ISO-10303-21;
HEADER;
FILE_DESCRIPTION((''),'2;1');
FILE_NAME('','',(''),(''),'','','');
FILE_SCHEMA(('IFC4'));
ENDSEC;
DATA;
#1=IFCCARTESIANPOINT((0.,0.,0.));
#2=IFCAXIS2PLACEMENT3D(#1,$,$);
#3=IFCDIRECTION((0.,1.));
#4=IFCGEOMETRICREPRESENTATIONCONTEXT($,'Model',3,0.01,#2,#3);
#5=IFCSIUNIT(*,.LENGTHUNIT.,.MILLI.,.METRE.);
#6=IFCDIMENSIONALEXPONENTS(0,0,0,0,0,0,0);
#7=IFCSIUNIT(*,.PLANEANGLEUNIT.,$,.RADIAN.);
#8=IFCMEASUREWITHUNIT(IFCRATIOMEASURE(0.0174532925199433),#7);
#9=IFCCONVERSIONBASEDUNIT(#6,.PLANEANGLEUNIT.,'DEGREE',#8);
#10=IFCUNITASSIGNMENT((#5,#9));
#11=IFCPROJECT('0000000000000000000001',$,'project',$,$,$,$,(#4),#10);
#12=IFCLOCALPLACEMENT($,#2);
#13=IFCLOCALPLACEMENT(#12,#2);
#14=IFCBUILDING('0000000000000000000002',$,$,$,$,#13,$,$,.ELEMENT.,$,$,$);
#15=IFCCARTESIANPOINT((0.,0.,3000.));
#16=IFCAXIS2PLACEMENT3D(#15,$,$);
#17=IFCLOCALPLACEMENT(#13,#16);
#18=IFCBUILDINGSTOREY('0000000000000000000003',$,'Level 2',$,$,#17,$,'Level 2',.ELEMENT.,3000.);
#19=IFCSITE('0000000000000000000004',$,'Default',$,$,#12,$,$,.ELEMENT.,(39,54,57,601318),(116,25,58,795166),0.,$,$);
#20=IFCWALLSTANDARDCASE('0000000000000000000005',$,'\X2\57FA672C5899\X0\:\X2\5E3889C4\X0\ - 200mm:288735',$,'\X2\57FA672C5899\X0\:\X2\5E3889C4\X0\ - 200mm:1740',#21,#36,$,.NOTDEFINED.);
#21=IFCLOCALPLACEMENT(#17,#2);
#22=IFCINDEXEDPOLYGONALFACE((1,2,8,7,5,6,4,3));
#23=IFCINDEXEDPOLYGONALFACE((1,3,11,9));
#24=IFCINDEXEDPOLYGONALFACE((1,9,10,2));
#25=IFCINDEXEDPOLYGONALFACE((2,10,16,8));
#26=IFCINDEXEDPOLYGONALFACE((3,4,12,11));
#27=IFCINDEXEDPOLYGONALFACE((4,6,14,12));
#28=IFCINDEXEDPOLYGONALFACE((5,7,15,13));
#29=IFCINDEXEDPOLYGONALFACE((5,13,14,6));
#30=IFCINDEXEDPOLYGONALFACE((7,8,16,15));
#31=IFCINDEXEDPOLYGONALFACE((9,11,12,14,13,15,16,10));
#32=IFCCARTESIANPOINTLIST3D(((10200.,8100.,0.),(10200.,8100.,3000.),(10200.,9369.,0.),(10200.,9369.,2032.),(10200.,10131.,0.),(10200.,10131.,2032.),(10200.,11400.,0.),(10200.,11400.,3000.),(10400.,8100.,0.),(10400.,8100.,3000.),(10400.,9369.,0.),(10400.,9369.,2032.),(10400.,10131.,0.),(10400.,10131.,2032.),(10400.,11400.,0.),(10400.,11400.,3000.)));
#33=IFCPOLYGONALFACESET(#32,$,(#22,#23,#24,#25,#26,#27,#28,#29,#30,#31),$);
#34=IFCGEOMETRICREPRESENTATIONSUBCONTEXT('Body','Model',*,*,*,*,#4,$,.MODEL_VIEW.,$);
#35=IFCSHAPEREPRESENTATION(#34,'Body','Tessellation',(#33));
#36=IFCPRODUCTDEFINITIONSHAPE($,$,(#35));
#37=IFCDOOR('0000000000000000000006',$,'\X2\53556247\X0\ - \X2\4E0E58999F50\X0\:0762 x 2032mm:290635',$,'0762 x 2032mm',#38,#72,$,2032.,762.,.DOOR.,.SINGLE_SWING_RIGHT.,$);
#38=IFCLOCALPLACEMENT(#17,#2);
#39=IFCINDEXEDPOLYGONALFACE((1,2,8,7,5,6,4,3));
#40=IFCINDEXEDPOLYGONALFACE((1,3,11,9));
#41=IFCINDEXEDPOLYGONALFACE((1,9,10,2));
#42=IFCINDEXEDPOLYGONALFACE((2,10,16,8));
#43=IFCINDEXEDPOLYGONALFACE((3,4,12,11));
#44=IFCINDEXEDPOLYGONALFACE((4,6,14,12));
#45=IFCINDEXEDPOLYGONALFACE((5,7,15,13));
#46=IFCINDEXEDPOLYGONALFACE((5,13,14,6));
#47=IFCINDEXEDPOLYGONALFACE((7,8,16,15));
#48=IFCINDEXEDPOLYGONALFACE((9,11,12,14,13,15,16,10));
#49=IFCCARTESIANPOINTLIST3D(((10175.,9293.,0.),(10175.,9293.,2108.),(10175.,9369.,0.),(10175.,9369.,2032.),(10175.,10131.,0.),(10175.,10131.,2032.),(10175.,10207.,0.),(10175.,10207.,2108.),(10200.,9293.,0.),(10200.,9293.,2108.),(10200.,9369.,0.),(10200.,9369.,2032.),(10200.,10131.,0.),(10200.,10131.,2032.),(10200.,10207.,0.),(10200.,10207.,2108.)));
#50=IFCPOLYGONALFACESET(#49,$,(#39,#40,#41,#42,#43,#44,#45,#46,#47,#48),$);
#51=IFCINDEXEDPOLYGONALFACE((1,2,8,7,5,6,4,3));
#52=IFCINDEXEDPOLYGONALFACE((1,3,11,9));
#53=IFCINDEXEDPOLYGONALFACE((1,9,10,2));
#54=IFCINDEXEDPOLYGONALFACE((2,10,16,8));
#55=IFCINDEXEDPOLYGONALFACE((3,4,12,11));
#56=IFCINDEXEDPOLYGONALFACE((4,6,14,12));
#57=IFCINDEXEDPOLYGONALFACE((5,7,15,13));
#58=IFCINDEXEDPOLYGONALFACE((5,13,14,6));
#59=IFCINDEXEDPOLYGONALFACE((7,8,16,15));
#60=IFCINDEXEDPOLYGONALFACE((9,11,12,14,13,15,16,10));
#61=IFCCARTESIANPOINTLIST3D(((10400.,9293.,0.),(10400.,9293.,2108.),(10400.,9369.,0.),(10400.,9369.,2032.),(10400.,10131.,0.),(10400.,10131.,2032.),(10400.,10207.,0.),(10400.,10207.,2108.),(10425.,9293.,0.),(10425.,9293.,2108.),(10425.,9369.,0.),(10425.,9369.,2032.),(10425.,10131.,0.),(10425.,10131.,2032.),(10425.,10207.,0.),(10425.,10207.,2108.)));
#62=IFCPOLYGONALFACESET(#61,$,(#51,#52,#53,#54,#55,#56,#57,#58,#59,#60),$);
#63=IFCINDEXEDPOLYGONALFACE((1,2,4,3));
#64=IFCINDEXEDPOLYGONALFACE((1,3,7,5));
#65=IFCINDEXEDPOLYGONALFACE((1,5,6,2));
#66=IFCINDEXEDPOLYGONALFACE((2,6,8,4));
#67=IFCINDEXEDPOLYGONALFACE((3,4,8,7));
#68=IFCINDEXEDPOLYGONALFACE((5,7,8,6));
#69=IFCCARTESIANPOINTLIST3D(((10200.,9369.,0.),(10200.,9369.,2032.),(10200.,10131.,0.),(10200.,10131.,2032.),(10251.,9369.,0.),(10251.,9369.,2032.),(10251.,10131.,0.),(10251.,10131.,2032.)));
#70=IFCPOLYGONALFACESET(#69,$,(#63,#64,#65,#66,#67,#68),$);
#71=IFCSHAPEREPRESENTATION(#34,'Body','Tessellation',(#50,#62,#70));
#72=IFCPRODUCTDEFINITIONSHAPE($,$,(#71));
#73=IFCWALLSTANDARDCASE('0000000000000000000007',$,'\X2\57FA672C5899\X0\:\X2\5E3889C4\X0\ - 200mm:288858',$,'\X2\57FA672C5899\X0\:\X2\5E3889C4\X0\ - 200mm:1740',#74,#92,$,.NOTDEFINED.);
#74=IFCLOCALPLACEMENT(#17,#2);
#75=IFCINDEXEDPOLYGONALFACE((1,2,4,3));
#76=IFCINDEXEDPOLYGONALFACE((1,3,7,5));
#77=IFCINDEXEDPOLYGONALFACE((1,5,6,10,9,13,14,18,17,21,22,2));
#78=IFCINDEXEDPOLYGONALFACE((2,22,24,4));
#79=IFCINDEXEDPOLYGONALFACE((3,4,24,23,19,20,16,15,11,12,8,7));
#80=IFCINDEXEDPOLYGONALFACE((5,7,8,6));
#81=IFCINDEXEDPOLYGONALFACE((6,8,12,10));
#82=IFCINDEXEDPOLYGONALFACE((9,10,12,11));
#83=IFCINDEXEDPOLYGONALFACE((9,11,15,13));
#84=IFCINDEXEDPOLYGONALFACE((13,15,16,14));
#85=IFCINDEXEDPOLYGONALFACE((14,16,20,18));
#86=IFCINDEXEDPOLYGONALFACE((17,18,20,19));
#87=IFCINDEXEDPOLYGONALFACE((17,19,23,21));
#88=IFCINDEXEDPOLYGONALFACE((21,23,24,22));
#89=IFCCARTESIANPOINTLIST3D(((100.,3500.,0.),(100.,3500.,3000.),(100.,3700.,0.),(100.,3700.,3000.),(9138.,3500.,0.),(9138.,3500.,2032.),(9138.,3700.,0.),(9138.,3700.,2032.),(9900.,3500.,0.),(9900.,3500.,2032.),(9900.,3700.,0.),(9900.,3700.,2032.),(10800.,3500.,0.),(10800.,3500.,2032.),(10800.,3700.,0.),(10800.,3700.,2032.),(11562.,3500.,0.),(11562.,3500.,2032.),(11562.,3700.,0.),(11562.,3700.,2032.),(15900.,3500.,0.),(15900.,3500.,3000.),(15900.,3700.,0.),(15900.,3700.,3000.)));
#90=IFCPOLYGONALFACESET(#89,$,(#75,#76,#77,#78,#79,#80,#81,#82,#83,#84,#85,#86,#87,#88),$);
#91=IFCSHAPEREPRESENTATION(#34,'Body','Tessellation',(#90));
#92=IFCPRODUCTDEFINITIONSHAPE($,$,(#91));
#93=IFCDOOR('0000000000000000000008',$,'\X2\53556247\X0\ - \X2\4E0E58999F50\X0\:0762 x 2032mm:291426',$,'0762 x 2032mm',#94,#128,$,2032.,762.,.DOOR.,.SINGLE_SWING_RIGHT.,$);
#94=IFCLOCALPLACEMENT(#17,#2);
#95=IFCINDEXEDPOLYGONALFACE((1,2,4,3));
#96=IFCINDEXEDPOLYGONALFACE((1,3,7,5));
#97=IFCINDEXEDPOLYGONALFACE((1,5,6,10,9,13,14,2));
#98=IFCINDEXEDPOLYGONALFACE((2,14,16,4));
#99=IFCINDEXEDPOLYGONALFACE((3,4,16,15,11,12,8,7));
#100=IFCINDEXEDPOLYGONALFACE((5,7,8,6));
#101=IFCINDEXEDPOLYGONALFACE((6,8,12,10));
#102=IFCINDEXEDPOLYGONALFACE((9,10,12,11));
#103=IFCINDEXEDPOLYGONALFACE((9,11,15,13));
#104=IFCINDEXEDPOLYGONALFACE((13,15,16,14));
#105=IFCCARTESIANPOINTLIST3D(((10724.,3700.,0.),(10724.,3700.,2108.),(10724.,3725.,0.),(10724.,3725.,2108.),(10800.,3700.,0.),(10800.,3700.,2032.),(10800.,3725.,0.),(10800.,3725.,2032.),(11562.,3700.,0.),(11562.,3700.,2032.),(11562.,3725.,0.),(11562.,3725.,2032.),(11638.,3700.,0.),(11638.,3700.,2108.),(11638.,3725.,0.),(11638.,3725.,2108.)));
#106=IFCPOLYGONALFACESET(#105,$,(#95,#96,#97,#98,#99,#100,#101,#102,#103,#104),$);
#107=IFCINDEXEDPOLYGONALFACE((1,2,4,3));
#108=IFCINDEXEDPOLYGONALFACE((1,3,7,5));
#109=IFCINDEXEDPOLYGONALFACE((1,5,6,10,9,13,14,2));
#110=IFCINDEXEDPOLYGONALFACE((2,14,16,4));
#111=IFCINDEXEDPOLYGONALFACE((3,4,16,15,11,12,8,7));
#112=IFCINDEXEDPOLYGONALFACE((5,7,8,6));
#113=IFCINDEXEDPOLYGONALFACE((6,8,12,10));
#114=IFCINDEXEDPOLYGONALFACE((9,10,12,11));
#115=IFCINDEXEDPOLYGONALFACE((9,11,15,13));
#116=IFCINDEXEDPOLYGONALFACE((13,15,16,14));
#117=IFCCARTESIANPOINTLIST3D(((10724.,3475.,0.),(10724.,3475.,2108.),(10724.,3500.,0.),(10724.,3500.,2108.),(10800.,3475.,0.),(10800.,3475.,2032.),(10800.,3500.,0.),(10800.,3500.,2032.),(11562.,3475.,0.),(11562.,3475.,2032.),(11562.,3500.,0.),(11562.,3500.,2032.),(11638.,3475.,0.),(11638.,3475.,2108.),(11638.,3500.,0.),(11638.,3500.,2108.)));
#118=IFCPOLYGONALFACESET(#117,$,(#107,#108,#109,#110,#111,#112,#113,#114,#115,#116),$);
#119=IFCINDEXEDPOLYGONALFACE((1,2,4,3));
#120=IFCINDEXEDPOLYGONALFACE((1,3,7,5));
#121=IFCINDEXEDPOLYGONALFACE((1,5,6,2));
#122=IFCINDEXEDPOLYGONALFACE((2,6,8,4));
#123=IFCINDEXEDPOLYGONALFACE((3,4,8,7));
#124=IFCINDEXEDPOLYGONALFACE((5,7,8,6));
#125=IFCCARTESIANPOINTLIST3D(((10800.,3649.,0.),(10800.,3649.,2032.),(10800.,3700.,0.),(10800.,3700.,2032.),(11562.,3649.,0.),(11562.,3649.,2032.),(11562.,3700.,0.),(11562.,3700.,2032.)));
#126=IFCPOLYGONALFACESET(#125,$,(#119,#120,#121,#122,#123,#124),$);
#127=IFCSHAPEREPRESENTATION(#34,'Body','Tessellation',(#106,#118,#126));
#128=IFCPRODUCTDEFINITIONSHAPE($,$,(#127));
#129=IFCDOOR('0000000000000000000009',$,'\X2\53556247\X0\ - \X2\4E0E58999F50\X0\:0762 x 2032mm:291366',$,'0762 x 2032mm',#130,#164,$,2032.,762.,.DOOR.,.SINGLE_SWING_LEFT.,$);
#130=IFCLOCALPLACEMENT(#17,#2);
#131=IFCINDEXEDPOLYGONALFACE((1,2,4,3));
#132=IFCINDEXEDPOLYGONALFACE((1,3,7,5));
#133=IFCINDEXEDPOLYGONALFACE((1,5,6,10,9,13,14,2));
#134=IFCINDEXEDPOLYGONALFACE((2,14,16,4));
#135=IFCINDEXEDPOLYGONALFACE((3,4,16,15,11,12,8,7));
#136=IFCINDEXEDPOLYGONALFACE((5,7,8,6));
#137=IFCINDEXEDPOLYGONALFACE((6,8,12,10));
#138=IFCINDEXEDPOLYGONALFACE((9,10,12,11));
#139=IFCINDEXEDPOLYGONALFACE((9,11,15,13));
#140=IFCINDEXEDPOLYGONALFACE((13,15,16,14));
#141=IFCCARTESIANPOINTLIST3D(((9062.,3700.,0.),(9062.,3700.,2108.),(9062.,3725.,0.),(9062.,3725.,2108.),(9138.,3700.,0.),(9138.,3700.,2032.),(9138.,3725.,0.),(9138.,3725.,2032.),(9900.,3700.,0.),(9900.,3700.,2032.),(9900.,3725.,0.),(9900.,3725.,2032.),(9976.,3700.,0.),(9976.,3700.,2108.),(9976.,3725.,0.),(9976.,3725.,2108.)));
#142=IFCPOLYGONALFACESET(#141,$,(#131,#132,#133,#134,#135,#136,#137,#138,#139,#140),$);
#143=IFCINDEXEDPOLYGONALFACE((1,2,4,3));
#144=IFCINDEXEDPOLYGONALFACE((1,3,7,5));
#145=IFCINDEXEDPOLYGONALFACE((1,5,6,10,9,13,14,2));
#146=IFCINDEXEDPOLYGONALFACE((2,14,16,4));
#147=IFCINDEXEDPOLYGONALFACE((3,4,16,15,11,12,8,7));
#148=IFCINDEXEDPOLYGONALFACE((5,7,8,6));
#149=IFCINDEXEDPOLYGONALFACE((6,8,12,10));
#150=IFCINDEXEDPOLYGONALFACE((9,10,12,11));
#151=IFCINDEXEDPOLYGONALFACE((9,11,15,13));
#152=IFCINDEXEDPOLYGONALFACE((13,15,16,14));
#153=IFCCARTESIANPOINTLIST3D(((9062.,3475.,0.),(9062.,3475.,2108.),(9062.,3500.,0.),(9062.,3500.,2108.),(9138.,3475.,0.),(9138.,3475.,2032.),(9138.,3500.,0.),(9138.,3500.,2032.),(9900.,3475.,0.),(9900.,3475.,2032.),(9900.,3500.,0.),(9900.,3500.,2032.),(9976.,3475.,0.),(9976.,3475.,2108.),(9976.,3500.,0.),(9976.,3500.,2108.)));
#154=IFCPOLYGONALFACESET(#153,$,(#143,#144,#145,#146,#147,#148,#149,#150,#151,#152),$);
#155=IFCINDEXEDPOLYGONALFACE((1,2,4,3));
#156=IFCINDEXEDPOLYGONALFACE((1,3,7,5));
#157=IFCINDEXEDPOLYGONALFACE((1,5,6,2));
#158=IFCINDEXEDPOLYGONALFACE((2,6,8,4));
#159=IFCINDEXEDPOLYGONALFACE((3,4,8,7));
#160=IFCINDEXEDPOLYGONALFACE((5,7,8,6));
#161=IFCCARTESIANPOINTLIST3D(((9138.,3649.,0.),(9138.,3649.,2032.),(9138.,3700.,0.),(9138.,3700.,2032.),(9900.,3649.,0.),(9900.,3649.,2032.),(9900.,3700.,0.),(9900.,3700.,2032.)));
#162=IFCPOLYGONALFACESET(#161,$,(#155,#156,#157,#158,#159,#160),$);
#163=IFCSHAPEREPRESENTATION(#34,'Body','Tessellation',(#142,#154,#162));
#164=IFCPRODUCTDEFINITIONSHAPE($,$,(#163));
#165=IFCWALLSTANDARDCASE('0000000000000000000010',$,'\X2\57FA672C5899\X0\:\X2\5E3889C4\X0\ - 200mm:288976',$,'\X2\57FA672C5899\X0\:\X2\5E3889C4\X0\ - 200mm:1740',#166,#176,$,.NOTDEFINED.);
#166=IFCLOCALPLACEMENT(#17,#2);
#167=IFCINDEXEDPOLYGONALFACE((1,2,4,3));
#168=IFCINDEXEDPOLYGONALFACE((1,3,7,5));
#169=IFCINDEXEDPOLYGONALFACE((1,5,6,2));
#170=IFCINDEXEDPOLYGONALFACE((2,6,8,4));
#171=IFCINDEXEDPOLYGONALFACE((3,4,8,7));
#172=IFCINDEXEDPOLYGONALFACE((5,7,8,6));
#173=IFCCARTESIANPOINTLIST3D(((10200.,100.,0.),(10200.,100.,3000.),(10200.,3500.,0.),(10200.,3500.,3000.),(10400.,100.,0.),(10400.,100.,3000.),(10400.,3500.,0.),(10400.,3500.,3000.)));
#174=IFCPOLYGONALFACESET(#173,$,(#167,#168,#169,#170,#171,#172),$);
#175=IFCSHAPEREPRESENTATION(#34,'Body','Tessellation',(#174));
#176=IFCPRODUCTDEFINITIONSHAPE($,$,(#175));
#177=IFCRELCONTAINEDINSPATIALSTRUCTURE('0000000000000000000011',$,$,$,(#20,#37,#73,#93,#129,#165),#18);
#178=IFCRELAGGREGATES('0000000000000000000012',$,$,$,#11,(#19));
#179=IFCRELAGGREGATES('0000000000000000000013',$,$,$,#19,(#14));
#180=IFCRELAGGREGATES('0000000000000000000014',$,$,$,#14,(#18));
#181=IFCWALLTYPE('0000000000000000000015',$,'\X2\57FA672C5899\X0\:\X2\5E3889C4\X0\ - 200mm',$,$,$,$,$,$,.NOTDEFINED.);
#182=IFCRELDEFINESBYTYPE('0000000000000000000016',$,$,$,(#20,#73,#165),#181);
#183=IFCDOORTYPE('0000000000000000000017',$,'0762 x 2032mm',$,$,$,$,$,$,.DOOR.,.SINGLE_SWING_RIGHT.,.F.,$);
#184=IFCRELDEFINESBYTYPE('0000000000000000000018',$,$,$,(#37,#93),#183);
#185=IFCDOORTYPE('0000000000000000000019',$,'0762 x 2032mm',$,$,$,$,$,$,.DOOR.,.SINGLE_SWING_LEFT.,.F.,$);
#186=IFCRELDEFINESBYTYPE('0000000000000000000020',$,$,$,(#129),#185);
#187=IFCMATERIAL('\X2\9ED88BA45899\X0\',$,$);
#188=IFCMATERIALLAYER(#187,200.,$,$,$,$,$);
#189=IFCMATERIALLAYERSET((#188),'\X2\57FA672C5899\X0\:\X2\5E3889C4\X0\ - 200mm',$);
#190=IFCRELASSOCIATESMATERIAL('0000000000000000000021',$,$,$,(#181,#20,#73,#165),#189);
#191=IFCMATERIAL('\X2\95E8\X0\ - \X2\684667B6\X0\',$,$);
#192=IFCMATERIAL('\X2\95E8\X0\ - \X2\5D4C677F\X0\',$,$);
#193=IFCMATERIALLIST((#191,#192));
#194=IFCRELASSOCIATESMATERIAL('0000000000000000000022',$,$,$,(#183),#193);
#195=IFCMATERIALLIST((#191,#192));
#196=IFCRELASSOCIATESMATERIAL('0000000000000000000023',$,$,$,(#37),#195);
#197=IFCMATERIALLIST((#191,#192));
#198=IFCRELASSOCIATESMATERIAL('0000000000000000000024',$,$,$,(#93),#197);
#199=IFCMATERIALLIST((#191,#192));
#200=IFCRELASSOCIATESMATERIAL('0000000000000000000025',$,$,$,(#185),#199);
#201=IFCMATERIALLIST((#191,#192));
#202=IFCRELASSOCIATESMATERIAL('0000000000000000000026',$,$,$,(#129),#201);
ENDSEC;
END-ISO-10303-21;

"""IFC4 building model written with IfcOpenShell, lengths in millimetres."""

from ifc_helpers import new_model, entity, si_unit, converted_unit, direction, frame, frame_2d, origin, origin_2d_with_axis, place, context, subcontext, project, spatial, polyline, rectangle, outline, extrude, source, transform, mapped, material, material_list, layer, layer_set, layer_usage, type_object, type_shapes, element, fill, save


model = new_model("IFC4")

# Units and contexts
model_context = context("Model", 3, precision=0.01, world=origin(), true_north=direction((0.0, 1.0)))
body_context = subcontext(model_context, "Body", "Model", "MODEL_VIEW")
ifc_project = project(units=[si_unit("LENGTHUNIT", "METRE", prefix="MILLI"), converted_unit("PLANEANGLEUNIT", "DEGREE", entity("IfcRatioMeasure", 0.0174532925199433), si_unit("PLANEANGLEUNIT", "RADIAN"), dimensions=[0, 0, 0, 0, 0, 0, 0])], contexts=[model_context])

# Site, building, storey
site_placement = place(None, origin())
site = spatial("IfcSite", under=ifc_project, at=site_placement, Name="Default", CompositionType="ELEMENT", RefLatitude=(39, 54, 57, 601318), RefLongitude=(116, 25, 58, 795166), RefElevation=0.0)
building_placement = place(site_placement, origin())
building = spatial("IfcBuilding", under=site, at=building_placement, CompositionType="ELEMENT")
storey_placement = place(building_placement, frame((0.0, 0.0, 3000.0)))
storey = spatial("IfcBuildingStorey", under=building, at=storey_placement, Name="Level 2", LongName="Level 2", CompositionType="ELEMENT", Elevation=3000.0)

# Shared definitions
ifc_material_1 = material(Name="默认墙")
ifc_layer = layer(ifc_material_1, 200.0)
ifc_layer_set = layer_set([ifc_layer], Name="基本墙:常规 - 200mm")
wall_type = type_object("IfcWallType", Name="基本墙:常规 - 200mm", PredefinedType="NOTDEFINED", material=ifc_layer_set)

# Wall, opening, door
ifc_layer_usage_1 = layer_usage(ifc_layer_set, "AXIS2", "NEGATIVE", 100.0)
wall_1_placement = place(storey_placement, frame((10300.0, 11400.0, 0.0), z_axis=(0.0, 0.0, 1.0), x_axis=(0.0, -1.0, 0.0)))
wall_1 = element("IfcWallStandardCase", 1, at=wall_1_placement, inside=storey, type_object=wall_type, material=ifc_layer_usage_1, Name="基本墙:常规 - 200mm:288735", ObjectType="基本墙:常规 - 200mm:1740", PredefinedType="NOTDEFINED", context=body_context, shape_type="SweptSolid", body=[
    extrude(rectangle(XDim=3300.0, YDim=200.0, at=frame_2d((1650.0, 0.0), x_axis=(-1.0, 0.0))), origin(), (0.0, 0.0, 1.0), 3000.0),
])
opening_1_placement = place(wall_1_placement, frame((2031.0, 100.0, 0.0)))
opening_1 = element("IfcOpeningElement", 2, at=opening_1_placement, cuts=wall_1, ObjectType="Opening", PredefinedType="OPENING", context=body_context, shape_type="SweptSolid", body=[
    extrude(rectangle(XDim=762.0, YDim=2032.0, at=frame_2d((1016.0, 381.0), x_axis=(0.0, 1.0))), frame((0.0, 0.0, 0.0), z_axis=(0.0, -1.0, 0.0), x_axis=(0.0, 0.0, 1.0)), (0.0, 0.0, 1.0), 200.0),
])
ifc_material_2 = material(Name="门 - 框架")
ifc_material_3 = material(Name="门 - 嵌板")
ifc_material_list_1 = material_list([ifc_material_2, ifc_material_3])
ifc_material_list_2 = material_list([ifc_material_2, ifc_material_3])
door_type_1 = type_object("IfcDoorType", Name="0762 x 2032mm", OperationType="SINGLE_SWING_RIGHT", ParameterTakesPrecedence=False, PredefinedType="DOOR", material=ifc_material_list_2)
shared_shape_1 = source(origin(), body_context, "Body", "SweptSolid", [
    extrude(outline(polyline([(-457.0, -1073.0), (457.0, -1073.0), (457.0, 1035.0), (381.0, 1035.0), (381.0, -997.0), (-381.0, -997.0), (-381.0, 1035.0), (-457.0, 1035.0), (-457.0, -1073.0)])), frame((381.0, 200.0, 1035.0), z_axis=(0.0, 1.0, 0.0), x_axis=(1.0, 0.0, 0.0)), (0.0, 0.0, 1.0), 25.0),
    extrude(outline(polyline([(-1073.0, -457.0), (1035.0, -457.0), (1035.0, -381.0), (-997.0, -381.0), (-997.0, 381.0), (1035.0, 381.0), (1035.0, 457.0), (-1073.0, 457.0), (-1073.0, -457.0)])), frame((381.0, -25.0, 1035.0), z_axis=(0.0, 1.0, 0.0), x_axis=(0.0, 0.0, -1.0)), (0.0, 0.0, 1.0), 25.0),
    extrude(rectangle(XDim=51.0, YDim=762.0, at=origin_2d_with_axis()), frame((381.0, 174.5, 0.0), z_axis=(0.0, 0.0, 1.0), x_axis=(0.0, 1.0, 0.0)), (0.0, 0.0, 1.0), 2032.0),
])
type_shapes(door_type_1, [shared_shape_1])
door_1_placement = place(opening_1_placement, frame((0.0, 0.0, 0.0), z_axis=(0.0, 0.0, 1.0), x_axis=(-1.0, 0.0, 0.0)))
door_1 = element("IfcDoor", 3, at=door_1_placement, inside=storey, type_object=door_type_1, material=ifc_material_list_1, Name="单扇 - 与墙齐:0762 x 2032mm:290635", ObjectType="0762 x 2032mm", OperationType="SINGLE_SWING_RIGHT", OverallHeight=2032.0, OverallWidth=762.0, PredefinedType="DOOR", context=body_context, shape_type="MappedRepresentation", body=[
    mapped(shared_shape_1, transform((0.0, 0.0, 0.0), scale=1.0)),
])
fill(opening_1, door_1)

# Wall, openings, doors
ifc_layer_usage_2 = layer_usage(ifc_layer_set, "AXIS2", "NEGATIVE", 100.0)
wall_2_placement = place(storey_placement, frame((15900.0, 3600.0, 0.0), z_axis=(0.0, 0.0, 1.0), x_axis=(-1.0, 0.0, 0.0)))
wall_2 = element("IfcWallStandardCase", 4, at=wall_2_placement, inside=storey, type_object=wall_type, material=ifc_layer_usage_2, Name="基本墙:常规 - 200mm:288858", ObjectType="基本墙:常规 - 200mm:1740", PredefinedType="NOTDEFINED", context=body_context, shape_type="SweptSolid", body=[
    extrude(rectangle(XDim=15800.0, YDim=200.0, at=frame_2d((7900.0, 0.0), x_axis=(-1.0, 0.0))), origin(), (0.0, 0.0, 1.0), 3000.0),
])
opening_2_placement = place(wall_2_placement, frame((6762.0, 100.0, 0.0)))
opening_2 = element("IfcOpeningElement", 5, at=opening_2_placement, cuts=wall_2, ObjectType="Opening", PredefinedType="OPENING", context=body_context, shape_type="SweptSolid", body=[
    extrude(rectangle(XDim=762.0, YDim=2032.0, at=frame_2d((1016.0, 381.0), x_axis=(0.0, -1.0))), frame((0.0, 0.0, 0.0), z_axis=(0.0, -1.0, 0.0), x_axis=(0.0, 0.0, 1.0)), (0.0, 0.0, 1.0), 200.0),
])
opening_3_placement = place(wall_2_placement, frame((5100.0, 100.0, 0.0)))
opening_3 = element("IfcOpeningElement", 6, at=opening_3_placement, cuts=wall_2, ObjectType="Opening", PredefinedType="OPENING", context=body_context, shape_type="SweptSolid", body=[
    extrude(rectangle(XDim=762.0, YDim=2032.0, at=frame_2d((1016.0, 381.0), x_axis=(0.0, 1.0))), frame((0.0, 0.0, 0.0), z_axis=(0.0, -1.0, 0.0), x_axis=(0.0, 0.0, 1.0)), (0.0, 0.0, 1.0), 200.0),
])
ifc_material_list_3 = material_list([ifc_material_2, ifc_material_3])
door_2_placement = place(opening_3_placement, frame((0.0, 0.0, 0.0), z_axis=(0.0, 0.0, 1.0), x_axis=(-1.0, 0.0, 0.0)))
door_2 = element("IfcDoor", 7, at=door_2_placement, inside=storey, type_object=door_type_1, material=ifc_material_list_3, Name="单扇 - 与墙齐:0762 x 2032mm:291426", ObjectType="0762 x 2032mm", OperationType="SINGLE_SWING_RIGHT", OverallHeight=2032.0, OverallWidth=762.0, PredefinedType="DOOR", context=body_context, shape_type="MappedRepresentation", body=[
    mapped(shared_shape_1, transform((0.0, 0.0, 0.0), scale=1.0)),
])
fill(opening_3, door_2)
ifc_material_list_4 = material_list([ifc_material_2, ifc_material_3])
ifc_material_list_5 = material_list([ifc_material_2, ifc_material_3])
door_type_2 = type_object("IfcDoorType", Name="0762 x 2032mm", OperationType="SINGLE_SWING_LEFT", ParameterTakesPrecedence=False, PredefinedType="DOOR", material=ifc_material_list_5)
shared_shape_2 = source(origin(), body_context, "Body", "SweptSolid", [
    extrude(outline(polyline([(-457.0, -1073.0), (457.0, -1073.0), (457.0, 1035.0), (381.0, 1035.0), (381.0, -997.0), (-381.0, -997.0), (-381.0, 1035.0), (-457.0, 1035.0), (-457.0, -1073.0)])), frame((381.0, 225.0, 1035.0), z_axis=(0.0, -1.0, 0.0), x_axis=(-1.0, 0.0, 0.0)), (0.0, 0.0, 1.0), 25.0),
    extrude(outline(polyline([(-1073.0, -457.0), (1035.0, -457.0), (1035.0, -381.0), (-997.0, -381.0), (-997.0, 381.0), (1035.0, 381.0), (1035.0, 457.0), (-1073.0, 457.0), (-1073.0, -457.0)])), frame((381.0, 0.0, 1035.0), z_axis=(0.0, -1.0, 0.0), x_axis=(0.0, 0.0, -1.0)), (0.0, 0.0, 1.0), 25.0),
    extrude(rectangle(XDim=762.0, YDim=51.0, at=origin_2d_with_axis()), frame((381.0, 174.5, 0.0)), (0.0, 0.0, 1.0), 2032.0),
])
type_shapes(door_type_2, [shared_shape_2])
door_3_placement = place(opening_2_placement, frame((0.0, 0.0, 0.0), z_axis=(0.0, 0.0, 1.0), x_axis=(-1.0, 0.0, 0.0)))
door_3 = element("IfcDoor", 8, at=door_3_placement, inside=storey, type_object=door_type_2, material=ifc_material_list_4, Name="单扇 - 与墙齐:0762 x 2032mm:291366", ObjectType="0762 x 2032mm", OperationType="SINGLE_SWING_LEFT", OverallHeight=2032.0, OverallWidth=762.0, PredefinedType="DOOR", context=body_context, shape_type="MappedRepresentation", body=[
    mapped(shared_shape_2, transform((0.0, 0.0, 0.0), scale=1.0)),
])
fill(opening_2, door_3)

# Wall
ifc_layer_usage_3 = layer_usage(ifc_layer_set, "AXIS2", "NEGATIVE", 100.0)
wall_3_placement = place(storey_placement, frame((10300.0, 3500.0, 0.0), z_axis=(0.0, 0.0, 1.0), x_axis=(0.0, -1.0, 0.0)))
element("IfcWallStandardCase", 9, at=wall_3_placement, inside=storey, type_object=wall_type, material=ifc_layer_usage_3, Name="基本墙:常规 - 200mm:288976", ObjectType="基本墙:常规 - 200mm:1740", PredefinedType="NOTDEFINED", context=body_context, shape_type="SweptSolid", body=[
    extrude(rectangle(XDim=3400.0, YDim=200.0, at=frame_2d((1700.0, 0.0), x_axis=(-1.0, 0.0))), origin(), (0.0, 0.0, 1.0), 3000.0),
])

save(model, "model.ifc")
